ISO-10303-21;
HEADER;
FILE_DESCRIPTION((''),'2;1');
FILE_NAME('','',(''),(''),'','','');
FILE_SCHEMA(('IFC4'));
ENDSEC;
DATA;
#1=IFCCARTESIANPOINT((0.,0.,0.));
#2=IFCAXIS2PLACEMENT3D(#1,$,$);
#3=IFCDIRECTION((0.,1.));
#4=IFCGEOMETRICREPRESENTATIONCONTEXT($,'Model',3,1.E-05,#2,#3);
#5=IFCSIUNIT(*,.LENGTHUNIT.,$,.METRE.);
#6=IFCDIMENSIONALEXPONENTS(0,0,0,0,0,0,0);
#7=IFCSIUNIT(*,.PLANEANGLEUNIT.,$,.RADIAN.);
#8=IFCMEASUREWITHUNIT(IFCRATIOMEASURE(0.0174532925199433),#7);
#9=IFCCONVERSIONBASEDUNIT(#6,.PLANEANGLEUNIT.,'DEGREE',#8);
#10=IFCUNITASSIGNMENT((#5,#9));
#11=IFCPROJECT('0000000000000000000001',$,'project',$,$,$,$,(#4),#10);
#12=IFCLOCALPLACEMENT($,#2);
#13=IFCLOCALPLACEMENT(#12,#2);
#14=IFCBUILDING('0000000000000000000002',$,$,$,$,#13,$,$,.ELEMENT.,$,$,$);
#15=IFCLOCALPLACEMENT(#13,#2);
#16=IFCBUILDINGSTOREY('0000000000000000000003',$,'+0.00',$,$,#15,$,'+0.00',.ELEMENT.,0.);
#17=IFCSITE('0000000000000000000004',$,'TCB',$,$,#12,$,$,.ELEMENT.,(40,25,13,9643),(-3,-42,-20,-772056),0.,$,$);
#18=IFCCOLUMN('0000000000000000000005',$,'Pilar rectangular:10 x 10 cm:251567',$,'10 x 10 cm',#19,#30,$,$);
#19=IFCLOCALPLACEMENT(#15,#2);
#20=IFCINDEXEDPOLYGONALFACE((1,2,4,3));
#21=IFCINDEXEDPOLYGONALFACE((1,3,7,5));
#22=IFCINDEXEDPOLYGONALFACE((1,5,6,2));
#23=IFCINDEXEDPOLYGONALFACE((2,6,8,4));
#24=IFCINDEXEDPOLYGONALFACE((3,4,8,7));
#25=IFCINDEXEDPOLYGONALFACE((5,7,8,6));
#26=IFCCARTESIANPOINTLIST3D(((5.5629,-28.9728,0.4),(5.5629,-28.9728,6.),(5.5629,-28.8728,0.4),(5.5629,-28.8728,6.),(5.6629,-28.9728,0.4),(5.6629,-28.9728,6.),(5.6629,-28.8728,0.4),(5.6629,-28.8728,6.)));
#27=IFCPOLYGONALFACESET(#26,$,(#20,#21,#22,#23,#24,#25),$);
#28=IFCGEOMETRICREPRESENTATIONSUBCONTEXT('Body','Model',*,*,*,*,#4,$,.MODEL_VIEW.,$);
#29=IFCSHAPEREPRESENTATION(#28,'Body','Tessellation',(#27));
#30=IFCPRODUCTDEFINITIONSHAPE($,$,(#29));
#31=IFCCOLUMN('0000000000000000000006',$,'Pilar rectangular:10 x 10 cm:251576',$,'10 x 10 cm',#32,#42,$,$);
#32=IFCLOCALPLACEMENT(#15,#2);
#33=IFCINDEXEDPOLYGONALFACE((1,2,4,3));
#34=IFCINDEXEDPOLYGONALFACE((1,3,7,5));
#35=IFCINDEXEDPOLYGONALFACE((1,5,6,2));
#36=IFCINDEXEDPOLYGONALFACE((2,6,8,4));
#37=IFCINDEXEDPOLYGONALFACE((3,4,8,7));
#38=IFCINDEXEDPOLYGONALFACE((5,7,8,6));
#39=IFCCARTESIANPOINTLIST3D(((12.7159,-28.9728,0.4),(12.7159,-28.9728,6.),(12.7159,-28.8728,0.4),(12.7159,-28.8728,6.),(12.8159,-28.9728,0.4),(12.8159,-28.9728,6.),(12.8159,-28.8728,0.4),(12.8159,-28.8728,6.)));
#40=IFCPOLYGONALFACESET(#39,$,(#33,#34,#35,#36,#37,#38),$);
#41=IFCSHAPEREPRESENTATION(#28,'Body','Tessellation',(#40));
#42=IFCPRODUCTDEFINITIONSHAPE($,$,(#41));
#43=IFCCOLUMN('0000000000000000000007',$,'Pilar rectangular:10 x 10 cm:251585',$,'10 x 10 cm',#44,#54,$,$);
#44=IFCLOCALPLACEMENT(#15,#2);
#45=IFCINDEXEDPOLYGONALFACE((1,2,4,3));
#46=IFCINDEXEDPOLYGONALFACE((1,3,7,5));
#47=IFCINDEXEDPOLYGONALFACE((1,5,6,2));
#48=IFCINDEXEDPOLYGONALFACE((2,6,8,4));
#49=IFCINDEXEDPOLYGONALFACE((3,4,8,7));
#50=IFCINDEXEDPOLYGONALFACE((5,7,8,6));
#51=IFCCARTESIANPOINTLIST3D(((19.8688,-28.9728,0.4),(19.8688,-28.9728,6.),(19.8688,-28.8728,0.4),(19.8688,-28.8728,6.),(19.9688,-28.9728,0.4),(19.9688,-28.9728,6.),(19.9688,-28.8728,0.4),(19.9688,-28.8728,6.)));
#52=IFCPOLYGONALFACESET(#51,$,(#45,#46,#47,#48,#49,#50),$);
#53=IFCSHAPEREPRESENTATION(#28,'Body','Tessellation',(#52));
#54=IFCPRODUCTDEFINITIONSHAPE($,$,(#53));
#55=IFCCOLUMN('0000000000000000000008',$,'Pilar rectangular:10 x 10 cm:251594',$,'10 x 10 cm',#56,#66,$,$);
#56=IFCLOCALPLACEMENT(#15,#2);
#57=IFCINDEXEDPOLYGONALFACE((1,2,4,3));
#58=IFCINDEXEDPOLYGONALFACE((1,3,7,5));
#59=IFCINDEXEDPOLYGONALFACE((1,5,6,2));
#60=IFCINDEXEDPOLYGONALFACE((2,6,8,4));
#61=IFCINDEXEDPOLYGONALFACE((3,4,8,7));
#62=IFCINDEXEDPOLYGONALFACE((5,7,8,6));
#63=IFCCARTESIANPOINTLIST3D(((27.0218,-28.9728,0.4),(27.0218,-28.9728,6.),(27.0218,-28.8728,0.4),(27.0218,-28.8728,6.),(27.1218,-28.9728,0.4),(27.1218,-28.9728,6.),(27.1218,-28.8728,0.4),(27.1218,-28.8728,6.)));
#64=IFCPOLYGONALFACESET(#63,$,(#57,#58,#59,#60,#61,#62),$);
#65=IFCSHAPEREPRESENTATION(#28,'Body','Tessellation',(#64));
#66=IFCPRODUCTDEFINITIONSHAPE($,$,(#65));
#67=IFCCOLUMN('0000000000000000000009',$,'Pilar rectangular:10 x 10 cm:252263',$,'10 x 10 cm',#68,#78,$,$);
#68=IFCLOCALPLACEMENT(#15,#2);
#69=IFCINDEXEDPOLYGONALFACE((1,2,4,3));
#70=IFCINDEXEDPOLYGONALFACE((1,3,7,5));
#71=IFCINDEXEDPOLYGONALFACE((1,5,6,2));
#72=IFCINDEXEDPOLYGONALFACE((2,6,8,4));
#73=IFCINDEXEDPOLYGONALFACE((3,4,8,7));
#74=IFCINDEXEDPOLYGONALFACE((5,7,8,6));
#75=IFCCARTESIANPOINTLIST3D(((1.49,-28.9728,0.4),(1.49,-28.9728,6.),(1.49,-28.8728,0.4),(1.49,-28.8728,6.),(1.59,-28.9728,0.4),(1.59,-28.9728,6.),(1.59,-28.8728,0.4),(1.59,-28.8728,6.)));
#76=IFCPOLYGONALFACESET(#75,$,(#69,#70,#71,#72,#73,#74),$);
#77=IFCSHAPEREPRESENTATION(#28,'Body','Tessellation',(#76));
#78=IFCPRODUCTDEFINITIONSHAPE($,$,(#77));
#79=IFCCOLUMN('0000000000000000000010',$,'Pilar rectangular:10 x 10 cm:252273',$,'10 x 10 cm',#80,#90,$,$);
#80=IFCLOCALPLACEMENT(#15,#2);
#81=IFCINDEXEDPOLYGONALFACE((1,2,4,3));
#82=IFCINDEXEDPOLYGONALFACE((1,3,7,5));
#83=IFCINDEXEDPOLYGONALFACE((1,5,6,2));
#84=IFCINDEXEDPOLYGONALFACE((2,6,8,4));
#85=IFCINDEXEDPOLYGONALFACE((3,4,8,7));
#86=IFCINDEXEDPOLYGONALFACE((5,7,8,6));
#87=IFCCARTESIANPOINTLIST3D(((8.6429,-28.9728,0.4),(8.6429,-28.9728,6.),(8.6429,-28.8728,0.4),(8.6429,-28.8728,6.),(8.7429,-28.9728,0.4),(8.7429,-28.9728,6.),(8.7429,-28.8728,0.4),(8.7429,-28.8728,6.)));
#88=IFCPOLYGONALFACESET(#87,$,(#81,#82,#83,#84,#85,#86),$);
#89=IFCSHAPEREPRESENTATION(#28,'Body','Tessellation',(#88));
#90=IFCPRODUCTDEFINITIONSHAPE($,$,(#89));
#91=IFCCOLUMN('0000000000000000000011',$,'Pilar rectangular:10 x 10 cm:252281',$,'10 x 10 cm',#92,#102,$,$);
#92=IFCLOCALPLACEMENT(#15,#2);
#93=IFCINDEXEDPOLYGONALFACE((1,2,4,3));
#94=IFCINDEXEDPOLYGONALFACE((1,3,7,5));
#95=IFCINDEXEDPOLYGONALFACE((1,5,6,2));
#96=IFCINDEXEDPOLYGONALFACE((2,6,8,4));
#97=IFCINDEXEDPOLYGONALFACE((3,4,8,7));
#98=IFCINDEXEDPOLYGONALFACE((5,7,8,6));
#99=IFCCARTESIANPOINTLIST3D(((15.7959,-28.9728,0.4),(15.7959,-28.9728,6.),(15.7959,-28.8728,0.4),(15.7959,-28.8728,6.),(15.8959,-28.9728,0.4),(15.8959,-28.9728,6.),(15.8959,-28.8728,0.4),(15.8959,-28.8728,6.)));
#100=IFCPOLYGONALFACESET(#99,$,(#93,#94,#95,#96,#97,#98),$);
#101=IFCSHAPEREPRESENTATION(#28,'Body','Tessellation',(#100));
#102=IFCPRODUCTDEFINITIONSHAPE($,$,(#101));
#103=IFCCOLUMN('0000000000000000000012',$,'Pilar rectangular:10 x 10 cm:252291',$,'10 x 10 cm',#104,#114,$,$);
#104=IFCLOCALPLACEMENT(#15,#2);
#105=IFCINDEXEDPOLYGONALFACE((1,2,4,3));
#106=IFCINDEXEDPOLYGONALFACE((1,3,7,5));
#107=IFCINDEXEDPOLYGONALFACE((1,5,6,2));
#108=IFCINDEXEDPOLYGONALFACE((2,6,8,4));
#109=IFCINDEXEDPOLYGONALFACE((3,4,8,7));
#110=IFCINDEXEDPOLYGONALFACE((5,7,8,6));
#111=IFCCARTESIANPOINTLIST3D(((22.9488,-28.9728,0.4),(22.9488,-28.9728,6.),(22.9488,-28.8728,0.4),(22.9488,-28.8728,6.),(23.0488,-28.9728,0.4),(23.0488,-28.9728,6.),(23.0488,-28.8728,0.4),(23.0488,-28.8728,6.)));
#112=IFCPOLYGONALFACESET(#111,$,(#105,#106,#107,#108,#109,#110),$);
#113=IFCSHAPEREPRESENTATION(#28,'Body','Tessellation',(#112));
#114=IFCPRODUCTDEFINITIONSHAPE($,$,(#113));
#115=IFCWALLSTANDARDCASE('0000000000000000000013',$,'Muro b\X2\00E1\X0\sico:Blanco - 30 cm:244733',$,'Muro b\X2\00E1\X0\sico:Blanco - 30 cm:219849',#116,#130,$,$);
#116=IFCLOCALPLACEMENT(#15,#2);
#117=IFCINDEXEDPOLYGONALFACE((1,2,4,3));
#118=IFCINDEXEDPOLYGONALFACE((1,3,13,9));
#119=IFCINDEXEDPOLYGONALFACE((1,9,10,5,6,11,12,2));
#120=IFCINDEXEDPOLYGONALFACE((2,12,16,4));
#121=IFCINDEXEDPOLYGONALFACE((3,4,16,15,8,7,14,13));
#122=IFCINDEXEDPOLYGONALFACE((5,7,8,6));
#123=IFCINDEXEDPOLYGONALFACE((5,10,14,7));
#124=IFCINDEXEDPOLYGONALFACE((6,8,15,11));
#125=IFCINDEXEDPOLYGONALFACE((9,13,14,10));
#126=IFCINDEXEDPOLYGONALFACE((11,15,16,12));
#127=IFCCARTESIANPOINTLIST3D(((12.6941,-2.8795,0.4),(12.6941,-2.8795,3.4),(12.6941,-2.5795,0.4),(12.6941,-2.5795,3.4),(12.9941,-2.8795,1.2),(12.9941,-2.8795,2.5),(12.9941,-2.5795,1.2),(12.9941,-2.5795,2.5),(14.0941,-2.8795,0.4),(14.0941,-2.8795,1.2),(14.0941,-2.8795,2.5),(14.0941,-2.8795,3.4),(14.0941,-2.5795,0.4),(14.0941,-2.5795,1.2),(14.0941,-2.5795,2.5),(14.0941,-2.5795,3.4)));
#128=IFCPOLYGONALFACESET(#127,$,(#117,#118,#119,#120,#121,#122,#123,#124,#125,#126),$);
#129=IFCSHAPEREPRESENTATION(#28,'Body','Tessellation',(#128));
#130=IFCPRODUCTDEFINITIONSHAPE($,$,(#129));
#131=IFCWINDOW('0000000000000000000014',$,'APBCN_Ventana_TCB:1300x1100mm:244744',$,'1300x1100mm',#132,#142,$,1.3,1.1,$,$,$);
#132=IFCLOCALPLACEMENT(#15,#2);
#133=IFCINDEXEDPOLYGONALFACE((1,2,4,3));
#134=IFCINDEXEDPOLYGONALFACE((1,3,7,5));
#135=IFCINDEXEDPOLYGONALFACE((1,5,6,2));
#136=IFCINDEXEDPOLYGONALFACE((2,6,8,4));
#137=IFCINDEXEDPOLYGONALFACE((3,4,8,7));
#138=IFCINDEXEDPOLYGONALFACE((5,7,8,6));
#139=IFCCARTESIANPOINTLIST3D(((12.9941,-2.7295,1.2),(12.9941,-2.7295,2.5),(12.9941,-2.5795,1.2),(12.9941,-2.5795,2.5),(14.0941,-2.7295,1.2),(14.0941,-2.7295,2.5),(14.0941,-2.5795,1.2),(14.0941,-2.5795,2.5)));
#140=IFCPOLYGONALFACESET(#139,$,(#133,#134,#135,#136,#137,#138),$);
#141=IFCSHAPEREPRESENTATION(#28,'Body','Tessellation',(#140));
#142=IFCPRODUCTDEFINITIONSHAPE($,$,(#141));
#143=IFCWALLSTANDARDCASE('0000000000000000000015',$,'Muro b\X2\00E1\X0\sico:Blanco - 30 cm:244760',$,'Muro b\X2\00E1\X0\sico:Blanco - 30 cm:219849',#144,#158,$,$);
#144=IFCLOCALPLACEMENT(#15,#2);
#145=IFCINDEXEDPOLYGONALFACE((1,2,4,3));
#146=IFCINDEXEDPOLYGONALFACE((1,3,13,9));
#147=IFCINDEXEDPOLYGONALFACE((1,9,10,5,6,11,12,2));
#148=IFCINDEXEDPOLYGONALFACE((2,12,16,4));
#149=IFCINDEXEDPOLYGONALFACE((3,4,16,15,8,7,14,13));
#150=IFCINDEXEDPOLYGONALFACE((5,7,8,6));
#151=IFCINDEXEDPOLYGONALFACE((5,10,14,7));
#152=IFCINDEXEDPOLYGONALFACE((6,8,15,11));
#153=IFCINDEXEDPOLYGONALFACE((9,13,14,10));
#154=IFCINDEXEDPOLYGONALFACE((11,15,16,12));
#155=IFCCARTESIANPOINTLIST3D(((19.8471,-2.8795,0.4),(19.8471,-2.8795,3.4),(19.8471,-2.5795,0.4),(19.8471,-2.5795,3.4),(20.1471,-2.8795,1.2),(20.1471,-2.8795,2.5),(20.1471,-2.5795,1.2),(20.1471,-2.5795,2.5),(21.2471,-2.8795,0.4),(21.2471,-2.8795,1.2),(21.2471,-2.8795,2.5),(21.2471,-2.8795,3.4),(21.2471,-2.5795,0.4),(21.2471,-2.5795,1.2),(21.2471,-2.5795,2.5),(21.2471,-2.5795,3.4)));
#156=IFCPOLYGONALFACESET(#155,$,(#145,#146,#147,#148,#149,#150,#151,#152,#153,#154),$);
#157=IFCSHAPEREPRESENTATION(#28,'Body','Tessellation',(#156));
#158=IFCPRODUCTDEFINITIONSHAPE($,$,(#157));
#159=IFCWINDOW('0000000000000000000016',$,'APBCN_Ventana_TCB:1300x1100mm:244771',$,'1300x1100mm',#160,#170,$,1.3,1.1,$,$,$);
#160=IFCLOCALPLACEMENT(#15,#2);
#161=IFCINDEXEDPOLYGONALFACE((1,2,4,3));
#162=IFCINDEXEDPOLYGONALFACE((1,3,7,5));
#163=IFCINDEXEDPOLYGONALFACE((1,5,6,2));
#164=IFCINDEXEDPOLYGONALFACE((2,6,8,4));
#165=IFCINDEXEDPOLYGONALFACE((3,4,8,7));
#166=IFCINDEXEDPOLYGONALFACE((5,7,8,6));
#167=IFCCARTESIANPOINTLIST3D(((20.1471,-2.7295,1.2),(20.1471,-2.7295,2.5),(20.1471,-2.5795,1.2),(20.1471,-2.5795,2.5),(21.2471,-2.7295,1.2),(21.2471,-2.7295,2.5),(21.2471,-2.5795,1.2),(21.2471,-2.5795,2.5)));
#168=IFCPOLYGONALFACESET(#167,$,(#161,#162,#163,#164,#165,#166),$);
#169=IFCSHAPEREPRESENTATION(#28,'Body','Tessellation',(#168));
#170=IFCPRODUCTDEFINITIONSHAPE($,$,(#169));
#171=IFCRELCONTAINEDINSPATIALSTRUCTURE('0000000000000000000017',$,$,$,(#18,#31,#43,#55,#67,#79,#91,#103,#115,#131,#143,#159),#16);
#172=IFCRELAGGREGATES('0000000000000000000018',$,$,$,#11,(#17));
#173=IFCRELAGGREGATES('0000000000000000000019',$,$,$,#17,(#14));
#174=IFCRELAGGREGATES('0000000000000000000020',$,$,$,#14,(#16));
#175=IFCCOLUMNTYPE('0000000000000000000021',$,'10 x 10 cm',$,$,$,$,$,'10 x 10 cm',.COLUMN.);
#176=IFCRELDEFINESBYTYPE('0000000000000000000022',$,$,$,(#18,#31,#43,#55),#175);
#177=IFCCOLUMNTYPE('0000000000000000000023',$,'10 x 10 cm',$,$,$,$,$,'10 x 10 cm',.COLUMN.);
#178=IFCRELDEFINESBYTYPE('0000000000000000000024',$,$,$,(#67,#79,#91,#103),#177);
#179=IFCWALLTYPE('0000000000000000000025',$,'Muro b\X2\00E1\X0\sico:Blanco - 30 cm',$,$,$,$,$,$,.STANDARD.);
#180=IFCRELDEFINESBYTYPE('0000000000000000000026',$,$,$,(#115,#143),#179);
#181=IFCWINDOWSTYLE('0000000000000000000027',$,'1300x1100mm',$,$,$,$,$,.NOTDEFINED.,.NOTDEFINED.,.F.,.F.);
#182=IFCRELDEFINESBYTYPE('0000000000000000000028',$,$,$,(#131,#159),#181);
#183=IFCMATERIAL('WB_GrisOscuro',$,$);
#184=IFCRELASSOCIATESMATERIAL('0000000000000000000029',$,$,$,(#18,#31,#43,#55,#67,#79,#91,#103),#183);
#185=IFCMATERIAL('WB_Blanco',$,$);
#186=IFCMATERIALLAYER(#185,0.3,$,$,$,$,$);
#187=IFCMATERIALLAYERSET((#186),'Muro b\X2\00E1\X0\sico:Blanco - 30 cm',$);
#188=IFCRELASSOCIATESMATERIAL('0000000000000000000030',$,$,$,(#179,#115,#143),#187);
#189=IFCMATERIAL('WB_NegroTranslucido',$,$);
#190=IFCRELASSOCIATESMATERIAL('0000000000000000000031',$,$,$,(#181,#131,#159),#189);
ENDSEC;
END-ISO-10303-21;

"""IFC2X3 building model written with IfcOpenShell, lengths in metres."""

from ifc_helpers import new_model, entity, si_unit, converted_unit, direction, frame, frame_2d, origin, origin_2d_with_axis, place, context, subcontext, project, spatial, rectangle, extrude, source, transform, mapped, material, layer, layer_set, layer_usage, type_object, type_shapes, element, fill, save


model = new_model("IFC2X3")

# Units and contexts
model_context = context("Model", 3, precision=1e-05, world=origin(), true_north=direction((0.0, 1.0)))
body_context = subcontext(model_context, "Body", "Model", "MODEL_VIEW")
ifc_project = project(units=[si_unit("LENGTHUNIT", "METRE"), converted_unit("PLANEANGLEUNIT", "DEGREE", entity("IfcRatioMeasure", 0.0174532925199433), si_unit("PLANEANGLEUNIT", "RADIAN"), dimensions=[0, 0, 0, 0, 0, 0, 0])], contexts=[model_context])

# Site, building, storey
site_placement = place(None, origin())
site = spatial("IfcSite", under=ifc_project, at=site_placement, Name="TCB", CompositionType="ELEMENT", RefLatitude=(40, 25, 13, 9643), RefLongitude=(-3, -42, -20, -772056), RefElevation=0.0)
building_placement = place(site_placement, origin())
building = spatial("IfcBuilding", under=site, at=building_placement, CompositionType="ELEMENT")
storey_placement = place(building_placement, origin())
storey = spatial("IfcBuildingStorey", under=building, at=storey_placement, Name="+0.00", LongName="+0.00", CompositionType="ELEMENT", Elevation=0.0)

# Columns
ifc_material_1 = material(Name="WB_GrisOscuro")
column_type_1 = type_object("IfcColumnType", Name="10 x 10 cm", ElementType="10 x 10 cm", PredefinedType="COLUMN")
shared_shape_1 = source(origin(), body_context, "Body", "SweptSolid", [
    extrude(rectangle(XDim=0.1, YDim=0.1, at=origin_2d_with_axis()), frame((0.0, 0.0, 0.4), z_axis=(0.0, 0.0, 1.0), x_axis=(0.0, -1.0, 0.0)), (0.0, 0.0, 1.0), 5.6),
])
type_shapes(column_type_1, [shared_shape_1])
for number, where, name in (
    (1, (5.6129, -28.9228, 0.0), "Pilar rectangular:10 x 10 cm:251567"),
    (2, (12.7659, -28.9228, 0.0), "Pilar rectangular:10 x 10 cm:251576"),
    (3, (19.9188, -28.9228, 0.0), "Pilar rectangular:10 x 10 cm:251585"),
    (4, (27.0718, -28.9228, 0.0), "Pilar rectangular:10 x 10 cm:251594"),
):
    element("IfcColumn", number, at=place(storey_placement, frame(where)), inside=storey, type_object=column_type_1, material=ifc_material_1, Name=name, ObjectType="10 x 10 cm", context=body_context, shape_type="MappedRepresentation", body=[
        mapped(shared_shape_1, transform((0.0, 0.0, 0.0), scale=1.0)),
    ])
column_type_2 = type_object("IfcColumnType", Name="10 x 10 cm", ElementType="10 x 10 cm", PredefinedType="COLUMN")
shared_shape_2 = source(origin(), body_context, "Body", "SweptSolid", [
    extrude(rectangle(XDim=0.1, YDim=0.1, at=origin_2d_with_axis()), frame((0.0, 0.0, 0.4), z_axis=(0.0, 0.0, 1.0), x_axis=(0.0, -1.0, 0.0)), (0.0, 0.0, 1.0), 5.6),
])
type_shapes(column_type_2, [shared_shape_2])
for number, where, z_axis, x_axis, name in (
    (5, (1.54, -28.9228, 0.0), (0.0, 0.0, 1.0), (-1.0, 0.0, 0.0), "Pilar rectangular:10 x 10 cm:252263"),
    (6, (8.6929, -28.9228, 0.0), (0.0, 0.0, 1.0), (-1.0, 0.0, 0.0), "Pilar rectangular:10 x 10 cm:252273"),
    (7, (15.8459, -28.9228, 0.0), (0.0, 0.0, 1.0), (-1.0, 0.0, 0.0), "Pilar rectangular:10 x 10 cm:252281"),
    (8, (22.9988, -28.9228, 0.0), (0.0, 0.0, 1.0), (-1.0, 0.0, 0.0), "Pilar rectangular:10 x 10 cm:252291"),
):
    element("IfcColumn", number, at=place(storey_placement, frame(where, z_axis=z_axis, x_axis=x_axis)), inside=storey, type_object=column_type_2, material=ifc_material_1, Name=name, ObjectType="10 x 10 cm", context=body_context, shape_type="MappedRepresentation", body=[
        mapped(shared_shape_2, transform((0.0, 0.0, 0.0), scale=1.0)),
    ])

# Walls, openings, windows
ifc_material_2 = material(Name="WB_Blanco")
ifc_layer_1 = layer(ifc_material_2, 0.3)
ifc_layer_set_1 = layer_set([ifc_layer_1], Name="Muro básico:Blanco - 30 cm")
ifc_layer_usage_1 = layer_usage(ifc_layer_set_1, "AXIS2", "NEGATIVE", 0.15)
wall_type = type_object("IfcWallType", Name="Muro básico:Blanco - 30 cm", PredefinedType="STANDARD", material=ifc_layer_set_1)
wall_1_placement = place(storey_placement, frame((14.0941, -2.7295, 0.4), z_axis=(0.0, 0.0, 1.0), x_axis=(-1.0, 0.0, 0.0)))
wall_1 = element("IfcWallStandardCase", 9, at=wall_1_placement, inside=storey, type_object=wall_type, material=ifc_layer_usage_1, Name="Muro básico:Blanco - 30 cm:244733", ObjectType="Muro básico:Blanco - 30 cm:219849", context=body_context, shape_type="SweptSolid", body=[
    extrude(rectangle(XDim=1.4, YDim=0.3, at=frame_2d((0.7, 0.0), x_axis=(-1.0, 0.0))), origin(), (0.0, 0.0, 1.0), 3.0),
])
opening_1_placement = place(wall_1_placement, frame((0.0, -0.15, 0.8)))
opening_1 = element("IfcOpeningElement", 10, at=opening_1_placement, cuts=wall_1, ObjectType="Opening", context=body_context, shape_type="SweptSolid", body=[
    extrude(rectangle(XDim=1.3, YDim=1.1, at=frame_2d((0.65, 0.55), x_axis=(1.0, 0.0))), frame((0.0, 0.0, 0.0), z_axis=(0.0, 1.0, 0.0), x_axis=(0.0, 0.0, 1.0)), (0.0, 0.0, 1.0), 0.3),
])
ifc_material_3 = material(Name="WB_NegroTranslucido")
window_style = type_object("IfcWindowStyle", Name="1300x1100mm", ConstructionType="NOTDEFINED", OperationType="NOTDEFINED", ParameterTakesPrecedence=False, Sizeable=False, material=ifc_material_3)
shared_shape_3 = source(origin(), body_context, "Body", "SweptSolid", [
    extrude(rectangle(XDim=1.1, YDim=0.15, at=origin_2d_with_axis()), frame((0.55, 0.075, 0.0)), (0.0, 0.0, 1.0), 1.3),
])
type_shapes(window_style, [shared_shape_3])
window_1_placement = place(opening_1_placement, origin())
window_1 = element("IfcWindow", 11, at=window_1_placement, inside=storey, type_object=window_style, material=ifc_material_3, Name="APBCN_Ventana_TCB:1300x1100mm:244744", ObjectType="1300x1100mm", OverallHeight=1.3, OverallWidth=1.1, context=body_context, shape_type="MappedRepresentation", body=[
    mapped(shared_shape_3, transform((0.0, 0.0, 0.0), scale=1.0)),
])
fill(opening_1, window_1)
ifc_layer_usage_2 = layer_usage(ifc_layer_set_1, "AXIS2", "NEGATIVE", 0.15)
wall_2_placement = place(storey_placement, frame((21.2471, -2.7295, 0.4), z_axis=(0.0, 0.0, 1.0), x_axis=(-1.0, 0.0, 0.0)))
wall_2 = element("IfcWallStandardCase", 12, at=wall_2_placement, inside=storey, type_object=wall_type, material=ifc_layer_usage_2, Name="Muro básico:Blanco - 30 cm:244760", ObjectType="Muro básico:Blanco - 30 cm:219849", context=body_context, shape_type="SweptSolid", body=[
    extrude(rectangle(XDim=1.4, YDim=0.3, at=frame_2d((0.7, 0.0), x_axis=(-1.0, 0.0))), origin(), (0.0, 0.0, 1.0), 3.0),
])
opening_2_placement = place(wall_2_placement, frame((0.0, -0.15, 0.8)))
opening_2 = element("IfcOpeningElement", 13, at=opening_2_placement, cuts=wall_2, ObjectType="Opening", context=body_context, shape_type="SweptSolid", body=[
    extrude(rectangle(XDim=1.3, YDim=1.1, at=frame_2d((0.65, 0.55), x_axis=(1.0, 0.0))), frame((0.0, 0.0, 0.0), z_axis=(0.0, 1.0, 0.0), x_axis=(0.0, 0.0, 1.0)), (0.0, 0.0, 1.0), 0.3),
])
window_2_placement = place(opening_2_placement, origin())
window_2 = element("IfcWindow", 14, at=window_2_placement, inside=storey, type_object=window_style, material=ifc_material_3, Name="APBCN_Ventana_TCB:1300x1100mm:244771", ObjectType="1300x1100mm", OverallHeight=1.3, OverallWidth=1.1, context=body_context, shape_type="MappedRepresentation", body=[
    mapped(shared_shape_3, transform((0.0, 0.0, 0.0), scale=1.0)),
])
fill(opening_2, window_2)

save(model, "model.ifc")
